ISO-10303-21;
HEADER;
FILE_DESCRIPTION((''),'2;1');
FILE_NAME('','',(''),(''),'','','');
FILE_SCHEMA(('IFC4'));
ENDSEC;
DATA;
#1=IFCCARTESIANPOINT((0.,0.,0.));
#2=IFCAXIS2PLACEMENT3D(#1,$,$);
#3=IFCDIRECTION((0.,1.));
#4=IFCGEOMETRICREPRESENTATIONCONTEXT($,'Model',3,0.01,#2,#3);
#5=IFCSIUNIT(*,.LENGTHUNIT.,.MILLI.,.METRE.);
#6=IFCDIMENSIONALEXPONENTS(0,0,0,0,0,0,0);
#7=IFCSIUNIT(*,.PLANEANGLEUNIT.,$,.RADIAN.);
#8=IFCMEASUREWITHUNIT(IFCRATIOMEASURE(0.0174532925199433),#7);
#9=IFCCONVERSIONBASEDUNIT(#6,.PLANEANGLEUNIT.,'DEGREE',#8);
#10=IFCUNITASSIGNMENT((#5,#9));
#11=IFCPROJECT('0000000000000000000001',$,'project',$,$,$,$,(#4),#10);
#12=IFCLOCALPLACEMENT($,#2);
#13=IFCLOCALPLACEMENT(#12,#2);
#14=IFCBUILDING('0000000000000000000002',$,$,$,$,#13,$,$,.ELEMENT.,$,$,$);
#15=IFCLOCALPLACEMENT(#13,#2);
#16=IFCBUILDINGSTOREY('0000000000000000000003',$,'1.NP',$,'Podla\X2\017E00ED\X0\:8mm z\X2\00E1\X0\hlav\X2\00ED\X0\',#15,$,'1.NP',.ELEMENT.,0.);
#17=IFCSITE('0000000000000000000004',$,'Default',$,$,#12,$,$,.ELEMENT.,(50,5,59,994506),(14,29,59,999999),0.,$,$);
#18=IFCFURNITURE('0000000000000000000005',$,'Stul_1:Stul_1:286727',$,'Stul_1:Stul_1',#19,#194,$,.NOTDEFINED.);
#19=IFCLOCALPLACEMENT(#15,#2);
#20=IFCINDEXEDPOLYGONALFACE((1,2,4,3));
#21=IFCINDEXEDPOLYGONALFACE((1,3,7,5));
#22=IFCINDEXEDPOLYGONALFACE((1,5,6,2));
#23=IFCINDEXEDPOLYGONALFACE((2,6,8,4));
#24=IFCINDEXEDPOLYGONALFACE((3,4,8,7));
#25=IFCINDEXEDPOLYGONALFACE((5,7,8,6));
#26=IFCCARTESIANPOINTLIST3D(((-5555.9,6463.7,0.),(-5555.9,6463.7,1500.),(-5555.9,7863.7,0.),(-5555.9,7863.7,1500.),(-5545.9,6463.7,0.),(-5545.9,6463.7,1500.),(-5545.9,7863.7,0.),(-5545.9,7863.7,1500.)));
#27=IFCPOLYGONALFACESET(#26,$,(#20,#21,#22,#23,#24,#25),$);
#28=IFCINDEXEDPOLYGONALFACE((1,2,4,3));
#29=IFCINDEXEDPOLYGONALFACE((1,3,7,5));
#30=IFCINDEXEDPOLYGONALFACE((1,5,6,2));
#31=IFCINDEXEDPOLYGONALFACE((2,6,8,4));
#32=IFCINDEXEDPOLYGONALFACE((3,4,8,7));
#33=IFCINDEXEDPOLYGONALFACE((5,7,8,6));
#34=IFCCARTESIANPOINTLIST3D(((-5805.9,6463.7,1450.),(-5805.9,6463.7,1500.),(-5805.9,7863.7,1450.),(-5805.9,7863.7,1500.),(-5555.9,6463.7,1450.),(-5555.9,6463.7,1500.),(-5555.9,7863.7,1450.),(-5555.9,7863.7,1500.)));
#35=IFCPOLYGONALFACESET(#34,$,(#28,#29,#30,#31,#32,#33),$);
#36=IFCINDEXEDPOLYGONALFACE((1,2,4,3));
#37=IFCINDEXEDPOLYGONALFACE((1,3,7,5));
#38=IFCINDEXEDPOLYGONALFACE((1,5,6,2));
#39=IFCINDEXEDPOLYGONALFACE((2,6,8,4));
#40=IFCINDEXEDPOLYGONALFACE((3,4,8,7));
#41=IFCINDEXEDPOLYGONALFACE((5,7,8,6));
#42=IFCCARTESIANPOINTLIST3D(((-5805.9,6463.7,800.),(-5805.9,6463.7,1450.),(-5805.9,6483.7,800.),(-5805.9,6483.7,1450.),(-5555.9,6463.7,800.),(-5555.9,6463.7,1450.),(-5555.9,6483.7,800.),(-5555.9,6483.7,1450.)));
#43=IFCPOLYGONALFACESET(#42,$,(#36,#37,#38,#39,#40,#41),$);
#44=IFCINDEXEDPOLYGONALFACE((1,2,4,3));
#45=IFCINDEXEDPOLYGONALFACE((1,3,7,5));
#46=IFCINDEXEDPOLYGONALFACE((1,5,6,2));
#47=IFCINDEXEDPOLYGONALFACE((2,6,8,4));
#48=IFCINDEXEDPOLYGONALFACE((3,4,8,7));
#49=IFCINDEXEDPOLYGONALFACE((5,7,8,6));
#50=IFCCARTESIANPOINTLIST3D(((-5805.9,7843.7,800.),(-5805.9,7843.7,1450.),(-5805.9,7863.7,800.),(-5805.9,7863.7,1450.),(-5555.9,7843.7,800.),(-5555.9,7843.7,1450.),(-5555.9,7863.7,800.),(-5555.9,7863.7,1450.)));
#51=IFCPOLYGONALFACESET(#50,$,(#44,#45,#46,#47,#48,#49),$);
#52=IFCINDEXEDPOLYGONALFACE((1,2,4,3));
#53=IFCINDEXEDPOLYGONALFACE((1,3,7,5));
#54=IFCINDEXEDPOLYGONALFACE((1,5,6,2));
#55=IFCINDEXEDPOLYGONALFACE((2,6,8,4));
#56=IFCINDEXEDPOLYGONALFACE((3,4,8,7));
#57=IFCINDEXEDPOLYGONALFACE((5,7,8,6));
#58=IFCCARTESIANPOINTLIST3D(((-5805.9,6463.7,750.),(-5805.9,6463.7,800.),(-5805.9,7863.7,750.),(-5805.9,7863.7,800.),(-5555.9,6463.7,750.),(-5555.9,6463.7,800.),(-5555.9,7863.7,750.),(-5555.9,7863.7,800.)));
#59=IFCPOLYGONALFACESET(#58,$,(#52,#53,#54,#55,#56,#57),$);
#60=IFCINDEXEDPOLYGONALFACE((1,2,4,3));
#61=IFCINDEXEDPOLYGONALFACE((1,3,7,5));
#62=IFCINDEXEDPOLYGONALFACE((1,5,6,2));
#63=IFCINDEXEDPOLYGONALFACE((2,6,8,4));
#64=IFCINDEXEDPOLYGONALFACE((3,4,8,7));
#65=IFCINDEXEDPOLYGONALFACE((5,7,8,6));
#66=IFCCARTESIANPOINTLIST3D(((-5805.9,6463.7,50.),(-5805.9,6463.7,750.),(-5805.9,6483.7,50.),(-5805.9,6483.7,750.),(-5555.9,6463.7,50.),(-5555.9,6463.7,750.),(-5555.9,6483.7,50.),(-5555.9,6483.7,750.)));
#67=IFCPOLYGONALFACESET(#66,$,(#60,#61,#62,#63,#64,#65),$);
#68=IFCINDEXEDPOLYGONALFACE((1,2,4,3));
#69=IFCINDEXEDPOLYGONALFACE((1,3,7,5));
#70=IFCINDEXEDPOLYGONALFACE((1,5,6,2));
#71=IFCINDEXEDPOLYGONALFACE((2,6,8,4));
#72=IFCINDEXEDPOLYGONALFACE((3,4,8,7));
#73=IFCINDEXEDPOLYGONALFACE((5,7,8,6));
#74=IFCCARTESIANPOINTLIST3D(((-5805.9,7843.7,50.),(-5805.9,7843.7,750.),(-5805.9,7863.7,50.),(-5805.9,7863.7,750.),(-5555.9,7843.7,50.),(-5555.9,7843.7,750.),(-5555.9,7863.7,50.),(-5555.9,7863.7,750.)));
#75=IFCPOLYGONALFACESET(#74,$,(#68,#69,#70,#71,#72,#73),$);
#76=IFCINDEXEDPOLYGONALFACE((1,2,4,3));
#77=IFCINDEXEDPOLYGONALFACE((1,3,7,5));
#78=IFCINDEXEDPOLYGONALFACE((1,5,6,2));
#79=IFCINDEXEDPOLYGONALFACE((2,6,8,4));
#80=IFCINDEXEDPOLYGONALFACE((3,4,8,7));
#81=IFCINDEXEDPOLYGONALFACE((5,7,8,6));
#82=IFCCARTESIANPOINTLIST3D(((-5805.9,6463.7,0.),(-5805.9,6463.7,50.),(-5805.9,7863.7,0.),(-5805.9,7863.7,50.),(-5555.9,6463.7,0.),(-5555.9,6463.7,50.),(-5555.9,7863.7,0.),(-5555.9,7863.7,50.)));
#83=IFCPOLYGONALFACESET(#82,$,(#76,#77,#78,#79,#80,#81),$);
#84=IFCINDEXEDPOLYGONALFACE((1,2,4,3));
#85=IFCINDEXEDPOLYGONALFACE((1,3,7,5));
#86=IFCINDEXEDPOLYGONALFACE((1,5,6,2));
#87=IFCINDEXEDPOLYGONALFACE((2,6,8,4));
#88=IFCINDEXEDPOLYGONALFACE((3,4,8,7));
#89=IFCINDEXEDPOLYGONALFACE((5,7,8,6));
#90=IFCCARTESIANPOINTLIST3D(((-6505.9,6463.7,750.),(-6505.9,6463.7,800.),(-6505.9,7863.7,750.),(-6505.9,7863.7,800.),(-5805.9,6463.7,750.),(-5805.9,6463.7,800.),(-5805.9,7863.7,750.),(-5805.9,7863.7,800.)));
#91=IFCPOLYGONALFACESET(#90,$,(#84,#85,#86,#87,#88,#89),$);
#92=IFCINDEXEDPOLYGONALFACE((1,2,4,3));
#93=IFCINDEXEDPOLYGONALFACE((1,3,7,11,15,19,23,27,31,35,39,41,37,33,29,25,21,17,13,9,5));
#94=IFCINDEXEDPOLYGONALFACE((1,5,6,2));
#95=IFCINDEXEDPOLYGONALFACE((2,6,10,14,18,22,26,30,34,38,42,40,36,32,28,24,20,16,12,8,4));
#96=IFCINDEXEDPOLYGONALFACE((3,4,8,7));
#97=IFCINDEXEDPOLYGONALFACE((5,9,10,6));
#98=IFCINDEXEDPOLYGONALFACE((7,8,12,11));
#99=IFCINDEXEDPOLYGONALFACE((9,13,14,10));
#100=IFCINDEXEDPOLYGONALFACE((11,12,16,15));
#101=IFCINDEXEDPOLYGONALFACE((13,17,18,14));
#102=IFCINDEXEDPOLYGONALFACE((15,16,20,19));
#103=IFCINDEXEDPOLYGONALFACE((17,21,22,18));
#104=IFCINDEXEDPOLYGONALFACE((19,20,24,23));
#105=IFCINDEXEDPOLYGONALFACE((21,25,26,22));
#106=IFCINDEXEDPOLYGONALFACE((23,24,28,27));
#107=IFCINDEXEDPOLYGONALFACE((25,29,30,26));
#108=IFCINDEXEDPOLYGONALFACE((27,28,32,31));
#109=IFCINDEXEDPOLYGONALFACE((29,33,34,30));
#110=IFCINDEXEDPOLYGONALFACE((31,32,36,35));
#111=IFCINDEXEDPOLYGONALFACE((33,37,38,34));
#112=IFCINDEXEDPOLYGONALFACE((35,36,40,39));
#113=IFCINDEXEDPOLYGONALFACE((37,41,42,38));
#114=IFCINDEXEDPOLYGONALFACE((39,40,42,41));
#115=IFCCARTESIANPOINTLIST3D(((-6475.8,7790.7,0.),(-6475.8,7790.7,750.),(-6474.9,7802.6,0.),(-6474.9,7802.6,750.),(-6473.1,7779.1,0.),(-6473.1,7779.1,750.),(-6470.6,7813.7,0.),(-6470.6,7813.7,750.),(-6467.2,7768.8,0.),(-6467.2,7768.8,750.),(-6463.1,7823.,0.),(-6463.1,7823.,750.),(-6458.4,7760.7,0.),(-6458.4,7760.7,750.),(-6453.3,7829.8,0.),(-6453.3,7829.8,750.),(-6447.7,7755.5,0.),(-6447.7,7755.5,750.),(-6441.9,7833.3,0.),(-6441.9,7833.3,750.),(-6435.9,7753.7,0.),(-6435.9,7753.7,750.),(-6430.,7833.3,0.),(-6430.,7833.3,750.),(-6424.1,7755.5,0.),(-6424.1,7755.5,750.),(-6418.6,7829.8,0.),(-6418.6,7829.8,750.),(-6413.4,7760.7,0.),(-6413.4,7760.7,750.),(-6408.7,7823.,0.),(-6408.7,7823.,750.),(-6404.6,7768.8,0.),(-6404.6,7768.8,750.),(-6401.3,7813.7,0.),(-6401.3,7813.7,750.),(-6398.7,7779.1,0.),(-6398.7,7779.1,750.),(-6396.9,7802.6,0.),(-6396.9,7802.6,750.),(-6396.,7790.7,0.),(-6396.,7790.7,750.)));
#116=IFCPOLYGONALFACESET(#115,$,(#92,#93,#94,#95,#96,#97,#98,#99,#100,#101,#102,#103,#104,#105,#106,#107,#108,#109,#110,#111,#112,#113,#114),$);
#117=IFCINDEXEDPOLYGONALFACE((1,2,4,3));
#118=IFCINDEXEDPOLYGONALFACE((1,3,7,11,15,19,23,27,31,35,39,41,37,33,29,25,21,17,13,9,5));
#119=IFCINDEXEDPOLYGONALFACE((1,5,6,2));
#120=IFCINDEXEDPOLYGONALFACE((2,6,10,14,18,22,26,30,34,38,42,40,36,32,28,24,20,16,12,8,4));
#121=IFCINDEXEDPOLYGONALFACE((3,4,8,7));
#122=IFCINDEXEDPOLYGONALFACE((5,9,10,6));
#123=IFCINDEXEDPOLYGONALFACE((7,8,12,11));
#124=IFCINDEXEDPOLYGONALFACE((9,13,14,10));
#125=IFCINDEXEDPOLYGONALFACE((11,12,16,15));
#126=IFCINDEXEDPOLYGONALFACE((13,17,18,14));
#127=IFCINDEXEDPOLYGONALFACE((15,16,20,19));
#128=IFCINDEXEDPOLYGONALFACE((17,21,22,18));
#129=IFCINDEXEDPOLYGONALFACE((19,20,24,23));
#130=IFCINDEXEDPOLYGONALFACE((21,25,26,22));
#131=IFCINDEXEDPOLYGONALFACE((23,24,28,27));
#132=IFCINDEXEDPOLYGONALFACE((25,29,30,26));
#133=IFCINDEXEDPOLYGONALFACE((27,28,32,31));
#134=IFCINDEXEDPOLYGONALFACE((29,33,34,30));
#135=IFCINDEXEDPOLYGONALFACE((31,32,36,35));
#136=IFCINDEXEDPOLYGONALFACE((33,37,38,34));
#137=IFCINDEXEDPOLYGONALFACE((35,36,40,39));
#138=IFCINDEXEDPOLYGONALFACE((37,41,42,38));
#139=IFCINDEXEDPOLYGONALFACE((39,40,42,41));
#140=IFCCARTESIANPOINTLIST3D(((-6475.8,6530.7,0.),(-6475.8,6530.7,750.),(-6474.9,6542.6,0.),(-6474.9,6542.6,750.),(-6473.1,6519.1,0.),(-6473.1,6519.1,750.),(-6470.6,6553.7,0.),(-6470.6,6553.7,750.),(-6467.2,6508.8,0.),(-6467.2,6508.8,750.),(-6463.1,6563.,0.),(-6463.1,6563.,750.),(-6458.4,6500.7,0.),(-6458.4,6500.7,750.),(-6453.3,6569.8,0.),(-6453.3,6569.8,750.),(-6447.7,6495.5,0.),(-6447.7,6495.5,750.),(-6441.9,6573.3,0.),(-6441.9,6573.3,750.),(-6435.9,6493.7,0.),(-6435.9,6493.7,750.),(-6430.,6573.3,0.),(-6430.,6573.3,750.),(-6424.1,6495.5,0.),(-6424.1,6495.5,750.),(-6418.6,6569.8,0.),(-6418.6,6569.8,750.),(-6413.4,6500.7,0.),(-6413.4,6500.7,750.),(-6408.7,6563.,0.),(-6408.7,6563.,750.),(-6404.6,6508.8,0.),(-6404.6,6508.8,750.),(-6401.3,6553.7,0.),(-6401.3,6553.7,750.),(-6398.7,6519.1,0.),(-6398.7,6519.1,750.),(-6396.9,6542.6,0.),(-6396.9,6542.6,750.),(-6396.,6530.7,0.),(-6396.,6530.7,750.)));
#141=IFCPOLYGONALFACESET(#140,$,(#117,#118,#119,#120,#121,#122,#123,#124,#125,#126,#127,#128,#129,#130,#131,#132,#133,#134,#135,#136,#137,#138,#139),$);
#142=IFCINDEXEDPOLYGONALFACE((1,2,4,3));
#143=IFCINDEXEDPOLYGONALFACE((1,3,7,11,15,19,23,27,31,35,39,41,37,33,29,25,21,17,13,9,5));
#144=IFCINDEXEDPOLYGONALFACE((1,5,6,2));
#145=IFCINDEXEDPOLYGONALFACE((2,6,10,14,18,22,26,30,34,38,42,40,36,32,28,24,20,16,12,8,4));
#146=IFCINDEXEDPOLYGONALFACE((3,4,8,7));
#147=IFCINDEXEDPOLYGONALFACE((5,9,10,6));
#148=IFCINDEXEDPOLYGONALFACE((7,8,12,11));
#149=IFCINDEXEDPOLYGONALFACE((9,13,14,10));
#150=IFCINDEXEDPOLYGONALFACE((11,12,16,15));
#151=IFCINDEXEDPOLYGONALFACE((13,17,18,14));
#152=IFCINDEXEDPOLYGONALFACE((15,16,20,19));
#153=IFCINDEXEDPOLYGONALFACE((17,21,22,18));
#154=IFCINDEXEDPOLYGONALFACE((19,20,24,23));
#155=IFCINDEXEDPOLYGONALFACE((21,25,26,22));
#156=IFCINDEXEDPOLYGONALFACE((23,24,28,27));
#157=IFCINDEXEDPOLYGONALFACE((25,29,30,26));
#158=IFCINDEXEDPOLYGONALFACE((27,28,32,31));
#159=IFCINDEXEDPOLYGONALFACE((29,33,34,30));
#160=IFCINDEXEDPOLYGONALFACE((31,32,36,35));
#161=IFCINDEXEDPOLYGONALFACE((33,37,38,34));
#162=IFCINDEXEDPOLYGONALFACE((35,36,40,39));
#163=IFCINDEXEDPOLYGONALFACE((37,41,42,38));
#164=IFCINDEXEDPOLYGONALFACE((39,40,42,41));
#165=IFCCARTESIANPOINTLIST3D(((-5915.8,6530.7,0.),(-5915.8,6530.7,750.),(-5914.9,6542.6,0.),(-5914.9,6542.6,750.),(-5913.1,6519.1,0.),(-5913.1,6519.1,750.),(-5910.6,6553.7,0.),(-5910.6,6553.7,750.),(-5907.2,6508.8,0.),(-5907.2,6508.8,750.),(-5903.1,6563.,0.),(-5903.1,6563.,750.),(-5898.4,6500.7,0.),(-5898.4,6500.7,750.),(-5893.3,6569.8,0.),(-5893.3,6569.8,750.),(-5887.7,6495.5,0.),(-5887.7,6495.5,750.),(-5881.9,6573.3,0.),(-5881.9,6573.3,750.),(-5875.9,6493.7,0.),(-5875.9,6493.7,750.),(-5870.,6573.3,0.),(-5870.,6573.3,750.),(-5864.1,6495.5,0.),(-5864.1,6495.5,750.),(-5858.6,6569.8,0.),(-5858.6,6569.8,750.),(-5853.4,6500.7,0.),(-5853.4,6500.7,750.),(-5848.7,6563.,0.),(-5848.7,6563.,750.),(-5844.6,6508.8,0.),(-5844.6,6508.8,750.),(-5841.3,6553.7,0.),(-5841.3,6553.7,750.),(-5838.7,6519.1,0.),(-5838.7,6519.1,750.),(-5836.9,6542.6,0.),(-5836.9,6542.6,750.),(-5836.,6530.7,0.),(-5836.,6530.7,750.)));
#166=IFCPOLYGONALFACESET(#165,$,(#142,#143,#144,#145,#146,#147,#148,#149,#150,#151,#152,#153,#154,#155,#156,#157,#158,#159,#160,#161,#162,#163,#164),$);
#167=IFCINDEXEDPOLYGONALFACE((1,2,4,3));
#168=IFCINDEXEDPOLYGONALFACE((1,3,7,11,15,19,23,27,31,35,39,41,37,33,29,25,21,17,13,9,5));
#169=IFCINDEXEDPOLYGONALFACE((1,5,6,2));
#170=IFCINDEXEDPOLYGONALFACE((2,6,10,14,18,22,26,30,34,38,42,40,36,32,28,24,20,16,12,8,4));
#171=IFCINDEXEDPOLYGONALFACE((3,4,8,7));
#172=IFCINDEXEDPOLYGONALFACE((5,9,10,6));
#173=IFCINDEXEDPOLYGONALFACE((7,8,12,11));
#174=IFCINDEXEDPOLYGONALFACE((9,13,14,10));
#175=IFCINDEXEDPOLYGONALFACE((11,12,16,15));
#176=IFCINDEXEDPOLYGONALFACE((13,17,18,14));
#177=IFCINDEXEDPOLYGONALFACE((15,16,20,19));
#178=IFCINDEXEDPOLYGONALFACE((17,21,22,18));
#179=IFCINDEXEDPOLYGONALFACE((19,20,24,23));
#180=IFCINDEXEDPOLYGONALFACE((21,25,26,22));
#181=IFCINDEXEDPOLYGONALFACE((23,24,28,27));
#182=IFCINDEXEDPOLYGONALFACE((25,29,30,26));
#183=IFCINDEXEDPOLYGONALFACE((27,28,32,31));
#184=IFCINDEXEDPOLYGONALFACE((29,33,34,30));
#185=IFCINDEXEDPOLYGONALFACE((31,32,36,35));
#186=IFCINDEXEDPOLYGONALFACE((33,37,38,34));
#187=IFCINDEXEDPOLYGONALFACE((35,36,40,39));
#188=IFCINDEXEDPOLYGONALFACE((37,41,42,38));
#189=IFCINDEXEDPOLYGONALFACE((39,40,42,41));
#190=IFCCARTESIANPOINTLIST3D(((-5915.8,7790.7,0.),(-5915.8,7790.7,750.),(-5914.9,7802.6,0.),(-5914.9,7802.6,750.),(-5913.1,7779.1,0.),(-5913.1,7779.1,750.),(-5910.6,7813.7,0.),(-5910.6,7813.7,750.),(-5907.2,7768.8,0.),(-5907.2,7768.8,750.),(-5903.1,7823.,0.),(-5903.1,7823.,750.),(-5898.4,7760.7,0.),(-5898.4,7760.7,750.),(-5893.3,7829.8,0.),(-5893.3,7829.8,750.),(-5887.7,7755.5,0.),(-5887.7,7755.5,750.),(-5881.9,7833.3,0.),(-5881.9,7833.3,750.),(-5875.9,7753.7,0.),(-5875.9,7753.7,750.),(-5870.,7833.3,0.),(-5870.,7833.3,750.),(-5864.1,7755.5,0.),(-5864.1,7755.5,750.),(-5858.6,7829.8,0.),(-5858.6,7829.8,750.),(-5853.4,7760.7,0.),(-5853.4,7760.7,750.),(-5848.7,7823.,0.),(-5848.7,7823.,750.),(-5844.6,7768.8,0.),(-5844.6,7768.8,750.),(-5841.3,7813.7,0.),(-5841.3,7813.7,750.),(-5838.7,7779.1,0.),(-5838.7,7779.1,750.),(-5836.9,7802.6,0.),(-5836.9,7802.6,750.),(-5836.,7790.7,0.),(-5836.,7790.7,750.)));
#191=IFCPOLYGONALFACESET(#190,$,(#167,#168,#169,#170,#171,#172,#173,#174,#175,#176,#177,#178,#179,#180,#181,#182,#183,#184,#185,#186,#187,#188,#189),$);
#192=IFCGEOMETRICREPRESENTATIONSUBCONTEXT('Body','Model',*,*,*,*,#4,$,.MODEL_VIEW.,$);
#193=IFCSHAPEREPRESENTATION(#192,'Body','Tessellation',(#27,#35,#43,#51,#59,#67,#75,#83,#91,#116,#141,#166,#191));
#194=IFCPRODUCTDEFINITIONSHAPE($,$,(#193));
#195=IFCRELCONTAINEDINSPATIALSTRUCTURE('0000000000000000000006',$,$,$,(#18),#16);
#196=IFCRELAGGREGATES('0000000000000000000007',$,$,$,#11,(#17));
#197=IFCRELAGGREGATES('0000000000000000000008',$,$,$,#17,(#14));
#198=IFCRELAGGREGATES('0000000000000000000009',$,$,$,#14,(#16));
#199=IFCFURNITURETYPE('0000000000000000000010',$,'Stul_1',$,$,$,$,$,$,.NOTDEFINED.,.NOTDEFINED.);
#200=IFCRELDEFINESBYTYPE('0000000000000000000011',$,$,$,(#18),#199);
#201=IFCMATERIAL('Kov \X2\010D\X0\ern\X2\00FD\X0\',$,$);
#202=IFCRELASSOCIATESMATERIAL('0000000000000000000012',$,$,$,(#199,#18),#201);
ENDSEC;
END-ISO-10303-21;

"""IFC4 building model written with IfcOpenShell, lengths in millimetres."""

from ifc_helpers import new_model, entity, si_unit, converted_unit, direction, frame, frame_2d, origin, origin_2d_with_axis, place, context, subcontext, project, spatial, rectangle, circle, extrude, source, transform, mapped, material, type_object, type_shapes, element, save


model = new_model("IFC4")

# Units and contexts
model_context = context("Model", 3, precision=0.01, world=origin(), true_north=direction((0.0, 1.0)))
body_context = subcontext(model_context, "Body", "Model", "MODEL_VIEW")
ifc_project = project(units=[si_unit("LENGTHUNIT", "METRE", prefix="MILLI"), converted_unit("PLANEANGLEUNIT", "DEGREE", entity("IfcRatioMeasure", 0.0174532925199433), si_unit("PLANEANGLEUNIT", "RADIAN"), dimensions=[0, 0, 0, 0, 0, 0, 0])], contexts=[model_context])

# Site, building, storey
site_placement = place(None, origin())
site = spatial("IfcSite", under=ifc_project, at=site_placement, Name="Default", CompositionType="ELEMENT", RefLatitude=(50, 5, 59, 994506), RefLongitude=(14, 29, 59, 999999), RefElevation=0.0)
building_placement = place(site_placement, origin())
building = spatial("IfcBuilding", under=site, at=building_placement, CompositionType="ELEMENT")
storey_placement = place(building_placement, origin())
storey = spatial("IfcBuildingStorey", under=building, at=storey_placement, Name="1.NP", ObjectType="Podlaží:8mm záhlaví", LongName="1.NP", CompositionType="ELEMENT", Elevation=0.0)

# Furniture
ifc_material_1 = material(Name="Kov černý")
furniture_type = type_object("IfcFurnitureType", Name="Stul_1", AssemblyPlace="NOTDEFINED", PredefinedType="NOTDEFINED", material=ifc_material_1)
shared_shape_1 = source(origin(), body_context, "Body", "SweptSolid", [
    extrude(rectangle(XDim=1400.0, YDim=10.0, at=origin_2d_with_axis()), frame((0.0, 605.0, 0.0), z_axis=(0.0, 0.0, 1.0), x_axis=(-1.0, 0.0, 0.0)), (0.0, 0.0, 1.0), 1500.0),
    extrude(rectangle(XDim=1400.0, YDim=250.0, at=frame_2d((0.0, 0.0), x_axis=(1.0, 0.0))), frame((0.0, 475.0, 1450.0), z_axis=(0.0, 0.0, 1.0), x_axis=(-1.0, 0.0, 0.0)), (0.0, 0.0, 1.0), 50.0),
    extrude(rectangle(XDim=20.0, YDim=250.0, at=origin_2d_with_axis()), frame((690.0, 475.0, 800.0), z_axis=(0.0, 0.0, 1.0), x_axis=(-1.0, 0.0, 0.0)), (0.0, 0.0, 1.0), 650.0),
    extrude(rectangle(XDim=20.0, YDim=250.0, at=frame_2d((0.0, 0.0), x_axis=(1.0, 0.0))), frame((-690.0, 475.0, 800.0), z_axis=(0.0, 0.0, 1.0), x_axis=(-1.0, 0.0, 0.0)), (0.0, 0.0, 1.0), 650.0),
    extrude(rectangle(XDim=1400.0, YDim=250.0, at=origin_2d_with_axis()), frame((0.0, 475.0, 750.0), z_axis=(0.0, 0.0, 1.0), x_axis=(-1.0, 0.0, 0.0)), (0.0, 0.0, 1.0), 50.0),
    extrude(rectangle(XDim=20.0, YDim=250.0, at=origin_2d_with_axis()), frame((690.0, 475.0, 50.0), z_axis=(0.0, 0.0, 1.0), x_axis=(-1.0, 0.0, 0.0)), (0.0, 0.0, 1.0), 700.0),
    extrude(rectangle(XDim=20.0, YDim=250.0, at=frame_2d((0.0, 0.0), x_axis=(1.0, 0.0))), frame((-690.0, 475.0, 50.0), z_axis=(0.0, 0.0, 1.0), x_axis=(-1.0, 0.0, 0.0)), (0.0, 0.0, 1.0), 700.0),
    extrude(rectangle(XDim=1400.0, YDim=250.0, at=origin_2d_with_axis()), frame((0.0, 475.0, 0.0), z_axis=(0.0, 0.0, 1.0), x_axis=(-1.0, 0.0, 0.0)), (0.0, 0.0, 1.0), 50.0),
    extrude(rectangle(XDim=1400.0, YDim=700.0, at=origin_2d_with_axis()), frame((0.0, 0.0, 750.0), z_axis=(0.0, 0.0, 1.0), x_axis=(-1.0, 0.0, 0.0)), (0.0, 0.0, 1.0), 50.0),
    extrude(circle(Radius=40.0, at=frame_2d((0.0, 0.0), x_axis=(1.0, 0.0))), frame((-630.0, -280.0, 0.0)), (0.0, 0.0, 1.0), 750.0),
    extrude(circle(Radius=40.0, at=frame_2d((0.0, 0.0), x_axis=(1.0, 0.0))), frame((630.0, -280.0, 0.0)), (0.0, 0.0, 1.0), 750.0),
    extrude(circle(Radius=40.0, at=frame_2d((0.0, 0.0), x_axis=(1.0, 0.0))), frame((630.0, 280.0, 0.0)), (0.0, 0.0, 1.0), 750.0),
    extrude(circle(Radius=40.0, at=frame_2d((0.0, 0.0), x_axis=(1.0, 0.0))), frame((-630.0, 280.0, 0.0)), (0.0, 0.0, 1.0), 750.0),
])
type_shapes(furniture_type, [shared_shape_1])
for number, where, z_axis, x_axis, name in (
    (1, (-6155.9, 7163.7, 0.0), (0.0, 0.0, 1.0), (0.0, -1.0, 0.0), "Stul_1:Stul_1:286727"),
):
    element("IfcFurniture", number, at=place(storey_placement, frame(where, z_axis=z_axis, x_axis=x_axis)), inside=storey, type_object=furniture_type, material=ifc_material_1, Name=name, ObjectType="Stul_1:Stul_1", PredefinedType="NOTDEFINED", context=body_context, shape_type="MappedRepresentation", body=[
        mapped(shared_shape_1, transform((0.0, 0.0, 0.0), scale=1.0)),
    ])

save(model, "model.ifc")
